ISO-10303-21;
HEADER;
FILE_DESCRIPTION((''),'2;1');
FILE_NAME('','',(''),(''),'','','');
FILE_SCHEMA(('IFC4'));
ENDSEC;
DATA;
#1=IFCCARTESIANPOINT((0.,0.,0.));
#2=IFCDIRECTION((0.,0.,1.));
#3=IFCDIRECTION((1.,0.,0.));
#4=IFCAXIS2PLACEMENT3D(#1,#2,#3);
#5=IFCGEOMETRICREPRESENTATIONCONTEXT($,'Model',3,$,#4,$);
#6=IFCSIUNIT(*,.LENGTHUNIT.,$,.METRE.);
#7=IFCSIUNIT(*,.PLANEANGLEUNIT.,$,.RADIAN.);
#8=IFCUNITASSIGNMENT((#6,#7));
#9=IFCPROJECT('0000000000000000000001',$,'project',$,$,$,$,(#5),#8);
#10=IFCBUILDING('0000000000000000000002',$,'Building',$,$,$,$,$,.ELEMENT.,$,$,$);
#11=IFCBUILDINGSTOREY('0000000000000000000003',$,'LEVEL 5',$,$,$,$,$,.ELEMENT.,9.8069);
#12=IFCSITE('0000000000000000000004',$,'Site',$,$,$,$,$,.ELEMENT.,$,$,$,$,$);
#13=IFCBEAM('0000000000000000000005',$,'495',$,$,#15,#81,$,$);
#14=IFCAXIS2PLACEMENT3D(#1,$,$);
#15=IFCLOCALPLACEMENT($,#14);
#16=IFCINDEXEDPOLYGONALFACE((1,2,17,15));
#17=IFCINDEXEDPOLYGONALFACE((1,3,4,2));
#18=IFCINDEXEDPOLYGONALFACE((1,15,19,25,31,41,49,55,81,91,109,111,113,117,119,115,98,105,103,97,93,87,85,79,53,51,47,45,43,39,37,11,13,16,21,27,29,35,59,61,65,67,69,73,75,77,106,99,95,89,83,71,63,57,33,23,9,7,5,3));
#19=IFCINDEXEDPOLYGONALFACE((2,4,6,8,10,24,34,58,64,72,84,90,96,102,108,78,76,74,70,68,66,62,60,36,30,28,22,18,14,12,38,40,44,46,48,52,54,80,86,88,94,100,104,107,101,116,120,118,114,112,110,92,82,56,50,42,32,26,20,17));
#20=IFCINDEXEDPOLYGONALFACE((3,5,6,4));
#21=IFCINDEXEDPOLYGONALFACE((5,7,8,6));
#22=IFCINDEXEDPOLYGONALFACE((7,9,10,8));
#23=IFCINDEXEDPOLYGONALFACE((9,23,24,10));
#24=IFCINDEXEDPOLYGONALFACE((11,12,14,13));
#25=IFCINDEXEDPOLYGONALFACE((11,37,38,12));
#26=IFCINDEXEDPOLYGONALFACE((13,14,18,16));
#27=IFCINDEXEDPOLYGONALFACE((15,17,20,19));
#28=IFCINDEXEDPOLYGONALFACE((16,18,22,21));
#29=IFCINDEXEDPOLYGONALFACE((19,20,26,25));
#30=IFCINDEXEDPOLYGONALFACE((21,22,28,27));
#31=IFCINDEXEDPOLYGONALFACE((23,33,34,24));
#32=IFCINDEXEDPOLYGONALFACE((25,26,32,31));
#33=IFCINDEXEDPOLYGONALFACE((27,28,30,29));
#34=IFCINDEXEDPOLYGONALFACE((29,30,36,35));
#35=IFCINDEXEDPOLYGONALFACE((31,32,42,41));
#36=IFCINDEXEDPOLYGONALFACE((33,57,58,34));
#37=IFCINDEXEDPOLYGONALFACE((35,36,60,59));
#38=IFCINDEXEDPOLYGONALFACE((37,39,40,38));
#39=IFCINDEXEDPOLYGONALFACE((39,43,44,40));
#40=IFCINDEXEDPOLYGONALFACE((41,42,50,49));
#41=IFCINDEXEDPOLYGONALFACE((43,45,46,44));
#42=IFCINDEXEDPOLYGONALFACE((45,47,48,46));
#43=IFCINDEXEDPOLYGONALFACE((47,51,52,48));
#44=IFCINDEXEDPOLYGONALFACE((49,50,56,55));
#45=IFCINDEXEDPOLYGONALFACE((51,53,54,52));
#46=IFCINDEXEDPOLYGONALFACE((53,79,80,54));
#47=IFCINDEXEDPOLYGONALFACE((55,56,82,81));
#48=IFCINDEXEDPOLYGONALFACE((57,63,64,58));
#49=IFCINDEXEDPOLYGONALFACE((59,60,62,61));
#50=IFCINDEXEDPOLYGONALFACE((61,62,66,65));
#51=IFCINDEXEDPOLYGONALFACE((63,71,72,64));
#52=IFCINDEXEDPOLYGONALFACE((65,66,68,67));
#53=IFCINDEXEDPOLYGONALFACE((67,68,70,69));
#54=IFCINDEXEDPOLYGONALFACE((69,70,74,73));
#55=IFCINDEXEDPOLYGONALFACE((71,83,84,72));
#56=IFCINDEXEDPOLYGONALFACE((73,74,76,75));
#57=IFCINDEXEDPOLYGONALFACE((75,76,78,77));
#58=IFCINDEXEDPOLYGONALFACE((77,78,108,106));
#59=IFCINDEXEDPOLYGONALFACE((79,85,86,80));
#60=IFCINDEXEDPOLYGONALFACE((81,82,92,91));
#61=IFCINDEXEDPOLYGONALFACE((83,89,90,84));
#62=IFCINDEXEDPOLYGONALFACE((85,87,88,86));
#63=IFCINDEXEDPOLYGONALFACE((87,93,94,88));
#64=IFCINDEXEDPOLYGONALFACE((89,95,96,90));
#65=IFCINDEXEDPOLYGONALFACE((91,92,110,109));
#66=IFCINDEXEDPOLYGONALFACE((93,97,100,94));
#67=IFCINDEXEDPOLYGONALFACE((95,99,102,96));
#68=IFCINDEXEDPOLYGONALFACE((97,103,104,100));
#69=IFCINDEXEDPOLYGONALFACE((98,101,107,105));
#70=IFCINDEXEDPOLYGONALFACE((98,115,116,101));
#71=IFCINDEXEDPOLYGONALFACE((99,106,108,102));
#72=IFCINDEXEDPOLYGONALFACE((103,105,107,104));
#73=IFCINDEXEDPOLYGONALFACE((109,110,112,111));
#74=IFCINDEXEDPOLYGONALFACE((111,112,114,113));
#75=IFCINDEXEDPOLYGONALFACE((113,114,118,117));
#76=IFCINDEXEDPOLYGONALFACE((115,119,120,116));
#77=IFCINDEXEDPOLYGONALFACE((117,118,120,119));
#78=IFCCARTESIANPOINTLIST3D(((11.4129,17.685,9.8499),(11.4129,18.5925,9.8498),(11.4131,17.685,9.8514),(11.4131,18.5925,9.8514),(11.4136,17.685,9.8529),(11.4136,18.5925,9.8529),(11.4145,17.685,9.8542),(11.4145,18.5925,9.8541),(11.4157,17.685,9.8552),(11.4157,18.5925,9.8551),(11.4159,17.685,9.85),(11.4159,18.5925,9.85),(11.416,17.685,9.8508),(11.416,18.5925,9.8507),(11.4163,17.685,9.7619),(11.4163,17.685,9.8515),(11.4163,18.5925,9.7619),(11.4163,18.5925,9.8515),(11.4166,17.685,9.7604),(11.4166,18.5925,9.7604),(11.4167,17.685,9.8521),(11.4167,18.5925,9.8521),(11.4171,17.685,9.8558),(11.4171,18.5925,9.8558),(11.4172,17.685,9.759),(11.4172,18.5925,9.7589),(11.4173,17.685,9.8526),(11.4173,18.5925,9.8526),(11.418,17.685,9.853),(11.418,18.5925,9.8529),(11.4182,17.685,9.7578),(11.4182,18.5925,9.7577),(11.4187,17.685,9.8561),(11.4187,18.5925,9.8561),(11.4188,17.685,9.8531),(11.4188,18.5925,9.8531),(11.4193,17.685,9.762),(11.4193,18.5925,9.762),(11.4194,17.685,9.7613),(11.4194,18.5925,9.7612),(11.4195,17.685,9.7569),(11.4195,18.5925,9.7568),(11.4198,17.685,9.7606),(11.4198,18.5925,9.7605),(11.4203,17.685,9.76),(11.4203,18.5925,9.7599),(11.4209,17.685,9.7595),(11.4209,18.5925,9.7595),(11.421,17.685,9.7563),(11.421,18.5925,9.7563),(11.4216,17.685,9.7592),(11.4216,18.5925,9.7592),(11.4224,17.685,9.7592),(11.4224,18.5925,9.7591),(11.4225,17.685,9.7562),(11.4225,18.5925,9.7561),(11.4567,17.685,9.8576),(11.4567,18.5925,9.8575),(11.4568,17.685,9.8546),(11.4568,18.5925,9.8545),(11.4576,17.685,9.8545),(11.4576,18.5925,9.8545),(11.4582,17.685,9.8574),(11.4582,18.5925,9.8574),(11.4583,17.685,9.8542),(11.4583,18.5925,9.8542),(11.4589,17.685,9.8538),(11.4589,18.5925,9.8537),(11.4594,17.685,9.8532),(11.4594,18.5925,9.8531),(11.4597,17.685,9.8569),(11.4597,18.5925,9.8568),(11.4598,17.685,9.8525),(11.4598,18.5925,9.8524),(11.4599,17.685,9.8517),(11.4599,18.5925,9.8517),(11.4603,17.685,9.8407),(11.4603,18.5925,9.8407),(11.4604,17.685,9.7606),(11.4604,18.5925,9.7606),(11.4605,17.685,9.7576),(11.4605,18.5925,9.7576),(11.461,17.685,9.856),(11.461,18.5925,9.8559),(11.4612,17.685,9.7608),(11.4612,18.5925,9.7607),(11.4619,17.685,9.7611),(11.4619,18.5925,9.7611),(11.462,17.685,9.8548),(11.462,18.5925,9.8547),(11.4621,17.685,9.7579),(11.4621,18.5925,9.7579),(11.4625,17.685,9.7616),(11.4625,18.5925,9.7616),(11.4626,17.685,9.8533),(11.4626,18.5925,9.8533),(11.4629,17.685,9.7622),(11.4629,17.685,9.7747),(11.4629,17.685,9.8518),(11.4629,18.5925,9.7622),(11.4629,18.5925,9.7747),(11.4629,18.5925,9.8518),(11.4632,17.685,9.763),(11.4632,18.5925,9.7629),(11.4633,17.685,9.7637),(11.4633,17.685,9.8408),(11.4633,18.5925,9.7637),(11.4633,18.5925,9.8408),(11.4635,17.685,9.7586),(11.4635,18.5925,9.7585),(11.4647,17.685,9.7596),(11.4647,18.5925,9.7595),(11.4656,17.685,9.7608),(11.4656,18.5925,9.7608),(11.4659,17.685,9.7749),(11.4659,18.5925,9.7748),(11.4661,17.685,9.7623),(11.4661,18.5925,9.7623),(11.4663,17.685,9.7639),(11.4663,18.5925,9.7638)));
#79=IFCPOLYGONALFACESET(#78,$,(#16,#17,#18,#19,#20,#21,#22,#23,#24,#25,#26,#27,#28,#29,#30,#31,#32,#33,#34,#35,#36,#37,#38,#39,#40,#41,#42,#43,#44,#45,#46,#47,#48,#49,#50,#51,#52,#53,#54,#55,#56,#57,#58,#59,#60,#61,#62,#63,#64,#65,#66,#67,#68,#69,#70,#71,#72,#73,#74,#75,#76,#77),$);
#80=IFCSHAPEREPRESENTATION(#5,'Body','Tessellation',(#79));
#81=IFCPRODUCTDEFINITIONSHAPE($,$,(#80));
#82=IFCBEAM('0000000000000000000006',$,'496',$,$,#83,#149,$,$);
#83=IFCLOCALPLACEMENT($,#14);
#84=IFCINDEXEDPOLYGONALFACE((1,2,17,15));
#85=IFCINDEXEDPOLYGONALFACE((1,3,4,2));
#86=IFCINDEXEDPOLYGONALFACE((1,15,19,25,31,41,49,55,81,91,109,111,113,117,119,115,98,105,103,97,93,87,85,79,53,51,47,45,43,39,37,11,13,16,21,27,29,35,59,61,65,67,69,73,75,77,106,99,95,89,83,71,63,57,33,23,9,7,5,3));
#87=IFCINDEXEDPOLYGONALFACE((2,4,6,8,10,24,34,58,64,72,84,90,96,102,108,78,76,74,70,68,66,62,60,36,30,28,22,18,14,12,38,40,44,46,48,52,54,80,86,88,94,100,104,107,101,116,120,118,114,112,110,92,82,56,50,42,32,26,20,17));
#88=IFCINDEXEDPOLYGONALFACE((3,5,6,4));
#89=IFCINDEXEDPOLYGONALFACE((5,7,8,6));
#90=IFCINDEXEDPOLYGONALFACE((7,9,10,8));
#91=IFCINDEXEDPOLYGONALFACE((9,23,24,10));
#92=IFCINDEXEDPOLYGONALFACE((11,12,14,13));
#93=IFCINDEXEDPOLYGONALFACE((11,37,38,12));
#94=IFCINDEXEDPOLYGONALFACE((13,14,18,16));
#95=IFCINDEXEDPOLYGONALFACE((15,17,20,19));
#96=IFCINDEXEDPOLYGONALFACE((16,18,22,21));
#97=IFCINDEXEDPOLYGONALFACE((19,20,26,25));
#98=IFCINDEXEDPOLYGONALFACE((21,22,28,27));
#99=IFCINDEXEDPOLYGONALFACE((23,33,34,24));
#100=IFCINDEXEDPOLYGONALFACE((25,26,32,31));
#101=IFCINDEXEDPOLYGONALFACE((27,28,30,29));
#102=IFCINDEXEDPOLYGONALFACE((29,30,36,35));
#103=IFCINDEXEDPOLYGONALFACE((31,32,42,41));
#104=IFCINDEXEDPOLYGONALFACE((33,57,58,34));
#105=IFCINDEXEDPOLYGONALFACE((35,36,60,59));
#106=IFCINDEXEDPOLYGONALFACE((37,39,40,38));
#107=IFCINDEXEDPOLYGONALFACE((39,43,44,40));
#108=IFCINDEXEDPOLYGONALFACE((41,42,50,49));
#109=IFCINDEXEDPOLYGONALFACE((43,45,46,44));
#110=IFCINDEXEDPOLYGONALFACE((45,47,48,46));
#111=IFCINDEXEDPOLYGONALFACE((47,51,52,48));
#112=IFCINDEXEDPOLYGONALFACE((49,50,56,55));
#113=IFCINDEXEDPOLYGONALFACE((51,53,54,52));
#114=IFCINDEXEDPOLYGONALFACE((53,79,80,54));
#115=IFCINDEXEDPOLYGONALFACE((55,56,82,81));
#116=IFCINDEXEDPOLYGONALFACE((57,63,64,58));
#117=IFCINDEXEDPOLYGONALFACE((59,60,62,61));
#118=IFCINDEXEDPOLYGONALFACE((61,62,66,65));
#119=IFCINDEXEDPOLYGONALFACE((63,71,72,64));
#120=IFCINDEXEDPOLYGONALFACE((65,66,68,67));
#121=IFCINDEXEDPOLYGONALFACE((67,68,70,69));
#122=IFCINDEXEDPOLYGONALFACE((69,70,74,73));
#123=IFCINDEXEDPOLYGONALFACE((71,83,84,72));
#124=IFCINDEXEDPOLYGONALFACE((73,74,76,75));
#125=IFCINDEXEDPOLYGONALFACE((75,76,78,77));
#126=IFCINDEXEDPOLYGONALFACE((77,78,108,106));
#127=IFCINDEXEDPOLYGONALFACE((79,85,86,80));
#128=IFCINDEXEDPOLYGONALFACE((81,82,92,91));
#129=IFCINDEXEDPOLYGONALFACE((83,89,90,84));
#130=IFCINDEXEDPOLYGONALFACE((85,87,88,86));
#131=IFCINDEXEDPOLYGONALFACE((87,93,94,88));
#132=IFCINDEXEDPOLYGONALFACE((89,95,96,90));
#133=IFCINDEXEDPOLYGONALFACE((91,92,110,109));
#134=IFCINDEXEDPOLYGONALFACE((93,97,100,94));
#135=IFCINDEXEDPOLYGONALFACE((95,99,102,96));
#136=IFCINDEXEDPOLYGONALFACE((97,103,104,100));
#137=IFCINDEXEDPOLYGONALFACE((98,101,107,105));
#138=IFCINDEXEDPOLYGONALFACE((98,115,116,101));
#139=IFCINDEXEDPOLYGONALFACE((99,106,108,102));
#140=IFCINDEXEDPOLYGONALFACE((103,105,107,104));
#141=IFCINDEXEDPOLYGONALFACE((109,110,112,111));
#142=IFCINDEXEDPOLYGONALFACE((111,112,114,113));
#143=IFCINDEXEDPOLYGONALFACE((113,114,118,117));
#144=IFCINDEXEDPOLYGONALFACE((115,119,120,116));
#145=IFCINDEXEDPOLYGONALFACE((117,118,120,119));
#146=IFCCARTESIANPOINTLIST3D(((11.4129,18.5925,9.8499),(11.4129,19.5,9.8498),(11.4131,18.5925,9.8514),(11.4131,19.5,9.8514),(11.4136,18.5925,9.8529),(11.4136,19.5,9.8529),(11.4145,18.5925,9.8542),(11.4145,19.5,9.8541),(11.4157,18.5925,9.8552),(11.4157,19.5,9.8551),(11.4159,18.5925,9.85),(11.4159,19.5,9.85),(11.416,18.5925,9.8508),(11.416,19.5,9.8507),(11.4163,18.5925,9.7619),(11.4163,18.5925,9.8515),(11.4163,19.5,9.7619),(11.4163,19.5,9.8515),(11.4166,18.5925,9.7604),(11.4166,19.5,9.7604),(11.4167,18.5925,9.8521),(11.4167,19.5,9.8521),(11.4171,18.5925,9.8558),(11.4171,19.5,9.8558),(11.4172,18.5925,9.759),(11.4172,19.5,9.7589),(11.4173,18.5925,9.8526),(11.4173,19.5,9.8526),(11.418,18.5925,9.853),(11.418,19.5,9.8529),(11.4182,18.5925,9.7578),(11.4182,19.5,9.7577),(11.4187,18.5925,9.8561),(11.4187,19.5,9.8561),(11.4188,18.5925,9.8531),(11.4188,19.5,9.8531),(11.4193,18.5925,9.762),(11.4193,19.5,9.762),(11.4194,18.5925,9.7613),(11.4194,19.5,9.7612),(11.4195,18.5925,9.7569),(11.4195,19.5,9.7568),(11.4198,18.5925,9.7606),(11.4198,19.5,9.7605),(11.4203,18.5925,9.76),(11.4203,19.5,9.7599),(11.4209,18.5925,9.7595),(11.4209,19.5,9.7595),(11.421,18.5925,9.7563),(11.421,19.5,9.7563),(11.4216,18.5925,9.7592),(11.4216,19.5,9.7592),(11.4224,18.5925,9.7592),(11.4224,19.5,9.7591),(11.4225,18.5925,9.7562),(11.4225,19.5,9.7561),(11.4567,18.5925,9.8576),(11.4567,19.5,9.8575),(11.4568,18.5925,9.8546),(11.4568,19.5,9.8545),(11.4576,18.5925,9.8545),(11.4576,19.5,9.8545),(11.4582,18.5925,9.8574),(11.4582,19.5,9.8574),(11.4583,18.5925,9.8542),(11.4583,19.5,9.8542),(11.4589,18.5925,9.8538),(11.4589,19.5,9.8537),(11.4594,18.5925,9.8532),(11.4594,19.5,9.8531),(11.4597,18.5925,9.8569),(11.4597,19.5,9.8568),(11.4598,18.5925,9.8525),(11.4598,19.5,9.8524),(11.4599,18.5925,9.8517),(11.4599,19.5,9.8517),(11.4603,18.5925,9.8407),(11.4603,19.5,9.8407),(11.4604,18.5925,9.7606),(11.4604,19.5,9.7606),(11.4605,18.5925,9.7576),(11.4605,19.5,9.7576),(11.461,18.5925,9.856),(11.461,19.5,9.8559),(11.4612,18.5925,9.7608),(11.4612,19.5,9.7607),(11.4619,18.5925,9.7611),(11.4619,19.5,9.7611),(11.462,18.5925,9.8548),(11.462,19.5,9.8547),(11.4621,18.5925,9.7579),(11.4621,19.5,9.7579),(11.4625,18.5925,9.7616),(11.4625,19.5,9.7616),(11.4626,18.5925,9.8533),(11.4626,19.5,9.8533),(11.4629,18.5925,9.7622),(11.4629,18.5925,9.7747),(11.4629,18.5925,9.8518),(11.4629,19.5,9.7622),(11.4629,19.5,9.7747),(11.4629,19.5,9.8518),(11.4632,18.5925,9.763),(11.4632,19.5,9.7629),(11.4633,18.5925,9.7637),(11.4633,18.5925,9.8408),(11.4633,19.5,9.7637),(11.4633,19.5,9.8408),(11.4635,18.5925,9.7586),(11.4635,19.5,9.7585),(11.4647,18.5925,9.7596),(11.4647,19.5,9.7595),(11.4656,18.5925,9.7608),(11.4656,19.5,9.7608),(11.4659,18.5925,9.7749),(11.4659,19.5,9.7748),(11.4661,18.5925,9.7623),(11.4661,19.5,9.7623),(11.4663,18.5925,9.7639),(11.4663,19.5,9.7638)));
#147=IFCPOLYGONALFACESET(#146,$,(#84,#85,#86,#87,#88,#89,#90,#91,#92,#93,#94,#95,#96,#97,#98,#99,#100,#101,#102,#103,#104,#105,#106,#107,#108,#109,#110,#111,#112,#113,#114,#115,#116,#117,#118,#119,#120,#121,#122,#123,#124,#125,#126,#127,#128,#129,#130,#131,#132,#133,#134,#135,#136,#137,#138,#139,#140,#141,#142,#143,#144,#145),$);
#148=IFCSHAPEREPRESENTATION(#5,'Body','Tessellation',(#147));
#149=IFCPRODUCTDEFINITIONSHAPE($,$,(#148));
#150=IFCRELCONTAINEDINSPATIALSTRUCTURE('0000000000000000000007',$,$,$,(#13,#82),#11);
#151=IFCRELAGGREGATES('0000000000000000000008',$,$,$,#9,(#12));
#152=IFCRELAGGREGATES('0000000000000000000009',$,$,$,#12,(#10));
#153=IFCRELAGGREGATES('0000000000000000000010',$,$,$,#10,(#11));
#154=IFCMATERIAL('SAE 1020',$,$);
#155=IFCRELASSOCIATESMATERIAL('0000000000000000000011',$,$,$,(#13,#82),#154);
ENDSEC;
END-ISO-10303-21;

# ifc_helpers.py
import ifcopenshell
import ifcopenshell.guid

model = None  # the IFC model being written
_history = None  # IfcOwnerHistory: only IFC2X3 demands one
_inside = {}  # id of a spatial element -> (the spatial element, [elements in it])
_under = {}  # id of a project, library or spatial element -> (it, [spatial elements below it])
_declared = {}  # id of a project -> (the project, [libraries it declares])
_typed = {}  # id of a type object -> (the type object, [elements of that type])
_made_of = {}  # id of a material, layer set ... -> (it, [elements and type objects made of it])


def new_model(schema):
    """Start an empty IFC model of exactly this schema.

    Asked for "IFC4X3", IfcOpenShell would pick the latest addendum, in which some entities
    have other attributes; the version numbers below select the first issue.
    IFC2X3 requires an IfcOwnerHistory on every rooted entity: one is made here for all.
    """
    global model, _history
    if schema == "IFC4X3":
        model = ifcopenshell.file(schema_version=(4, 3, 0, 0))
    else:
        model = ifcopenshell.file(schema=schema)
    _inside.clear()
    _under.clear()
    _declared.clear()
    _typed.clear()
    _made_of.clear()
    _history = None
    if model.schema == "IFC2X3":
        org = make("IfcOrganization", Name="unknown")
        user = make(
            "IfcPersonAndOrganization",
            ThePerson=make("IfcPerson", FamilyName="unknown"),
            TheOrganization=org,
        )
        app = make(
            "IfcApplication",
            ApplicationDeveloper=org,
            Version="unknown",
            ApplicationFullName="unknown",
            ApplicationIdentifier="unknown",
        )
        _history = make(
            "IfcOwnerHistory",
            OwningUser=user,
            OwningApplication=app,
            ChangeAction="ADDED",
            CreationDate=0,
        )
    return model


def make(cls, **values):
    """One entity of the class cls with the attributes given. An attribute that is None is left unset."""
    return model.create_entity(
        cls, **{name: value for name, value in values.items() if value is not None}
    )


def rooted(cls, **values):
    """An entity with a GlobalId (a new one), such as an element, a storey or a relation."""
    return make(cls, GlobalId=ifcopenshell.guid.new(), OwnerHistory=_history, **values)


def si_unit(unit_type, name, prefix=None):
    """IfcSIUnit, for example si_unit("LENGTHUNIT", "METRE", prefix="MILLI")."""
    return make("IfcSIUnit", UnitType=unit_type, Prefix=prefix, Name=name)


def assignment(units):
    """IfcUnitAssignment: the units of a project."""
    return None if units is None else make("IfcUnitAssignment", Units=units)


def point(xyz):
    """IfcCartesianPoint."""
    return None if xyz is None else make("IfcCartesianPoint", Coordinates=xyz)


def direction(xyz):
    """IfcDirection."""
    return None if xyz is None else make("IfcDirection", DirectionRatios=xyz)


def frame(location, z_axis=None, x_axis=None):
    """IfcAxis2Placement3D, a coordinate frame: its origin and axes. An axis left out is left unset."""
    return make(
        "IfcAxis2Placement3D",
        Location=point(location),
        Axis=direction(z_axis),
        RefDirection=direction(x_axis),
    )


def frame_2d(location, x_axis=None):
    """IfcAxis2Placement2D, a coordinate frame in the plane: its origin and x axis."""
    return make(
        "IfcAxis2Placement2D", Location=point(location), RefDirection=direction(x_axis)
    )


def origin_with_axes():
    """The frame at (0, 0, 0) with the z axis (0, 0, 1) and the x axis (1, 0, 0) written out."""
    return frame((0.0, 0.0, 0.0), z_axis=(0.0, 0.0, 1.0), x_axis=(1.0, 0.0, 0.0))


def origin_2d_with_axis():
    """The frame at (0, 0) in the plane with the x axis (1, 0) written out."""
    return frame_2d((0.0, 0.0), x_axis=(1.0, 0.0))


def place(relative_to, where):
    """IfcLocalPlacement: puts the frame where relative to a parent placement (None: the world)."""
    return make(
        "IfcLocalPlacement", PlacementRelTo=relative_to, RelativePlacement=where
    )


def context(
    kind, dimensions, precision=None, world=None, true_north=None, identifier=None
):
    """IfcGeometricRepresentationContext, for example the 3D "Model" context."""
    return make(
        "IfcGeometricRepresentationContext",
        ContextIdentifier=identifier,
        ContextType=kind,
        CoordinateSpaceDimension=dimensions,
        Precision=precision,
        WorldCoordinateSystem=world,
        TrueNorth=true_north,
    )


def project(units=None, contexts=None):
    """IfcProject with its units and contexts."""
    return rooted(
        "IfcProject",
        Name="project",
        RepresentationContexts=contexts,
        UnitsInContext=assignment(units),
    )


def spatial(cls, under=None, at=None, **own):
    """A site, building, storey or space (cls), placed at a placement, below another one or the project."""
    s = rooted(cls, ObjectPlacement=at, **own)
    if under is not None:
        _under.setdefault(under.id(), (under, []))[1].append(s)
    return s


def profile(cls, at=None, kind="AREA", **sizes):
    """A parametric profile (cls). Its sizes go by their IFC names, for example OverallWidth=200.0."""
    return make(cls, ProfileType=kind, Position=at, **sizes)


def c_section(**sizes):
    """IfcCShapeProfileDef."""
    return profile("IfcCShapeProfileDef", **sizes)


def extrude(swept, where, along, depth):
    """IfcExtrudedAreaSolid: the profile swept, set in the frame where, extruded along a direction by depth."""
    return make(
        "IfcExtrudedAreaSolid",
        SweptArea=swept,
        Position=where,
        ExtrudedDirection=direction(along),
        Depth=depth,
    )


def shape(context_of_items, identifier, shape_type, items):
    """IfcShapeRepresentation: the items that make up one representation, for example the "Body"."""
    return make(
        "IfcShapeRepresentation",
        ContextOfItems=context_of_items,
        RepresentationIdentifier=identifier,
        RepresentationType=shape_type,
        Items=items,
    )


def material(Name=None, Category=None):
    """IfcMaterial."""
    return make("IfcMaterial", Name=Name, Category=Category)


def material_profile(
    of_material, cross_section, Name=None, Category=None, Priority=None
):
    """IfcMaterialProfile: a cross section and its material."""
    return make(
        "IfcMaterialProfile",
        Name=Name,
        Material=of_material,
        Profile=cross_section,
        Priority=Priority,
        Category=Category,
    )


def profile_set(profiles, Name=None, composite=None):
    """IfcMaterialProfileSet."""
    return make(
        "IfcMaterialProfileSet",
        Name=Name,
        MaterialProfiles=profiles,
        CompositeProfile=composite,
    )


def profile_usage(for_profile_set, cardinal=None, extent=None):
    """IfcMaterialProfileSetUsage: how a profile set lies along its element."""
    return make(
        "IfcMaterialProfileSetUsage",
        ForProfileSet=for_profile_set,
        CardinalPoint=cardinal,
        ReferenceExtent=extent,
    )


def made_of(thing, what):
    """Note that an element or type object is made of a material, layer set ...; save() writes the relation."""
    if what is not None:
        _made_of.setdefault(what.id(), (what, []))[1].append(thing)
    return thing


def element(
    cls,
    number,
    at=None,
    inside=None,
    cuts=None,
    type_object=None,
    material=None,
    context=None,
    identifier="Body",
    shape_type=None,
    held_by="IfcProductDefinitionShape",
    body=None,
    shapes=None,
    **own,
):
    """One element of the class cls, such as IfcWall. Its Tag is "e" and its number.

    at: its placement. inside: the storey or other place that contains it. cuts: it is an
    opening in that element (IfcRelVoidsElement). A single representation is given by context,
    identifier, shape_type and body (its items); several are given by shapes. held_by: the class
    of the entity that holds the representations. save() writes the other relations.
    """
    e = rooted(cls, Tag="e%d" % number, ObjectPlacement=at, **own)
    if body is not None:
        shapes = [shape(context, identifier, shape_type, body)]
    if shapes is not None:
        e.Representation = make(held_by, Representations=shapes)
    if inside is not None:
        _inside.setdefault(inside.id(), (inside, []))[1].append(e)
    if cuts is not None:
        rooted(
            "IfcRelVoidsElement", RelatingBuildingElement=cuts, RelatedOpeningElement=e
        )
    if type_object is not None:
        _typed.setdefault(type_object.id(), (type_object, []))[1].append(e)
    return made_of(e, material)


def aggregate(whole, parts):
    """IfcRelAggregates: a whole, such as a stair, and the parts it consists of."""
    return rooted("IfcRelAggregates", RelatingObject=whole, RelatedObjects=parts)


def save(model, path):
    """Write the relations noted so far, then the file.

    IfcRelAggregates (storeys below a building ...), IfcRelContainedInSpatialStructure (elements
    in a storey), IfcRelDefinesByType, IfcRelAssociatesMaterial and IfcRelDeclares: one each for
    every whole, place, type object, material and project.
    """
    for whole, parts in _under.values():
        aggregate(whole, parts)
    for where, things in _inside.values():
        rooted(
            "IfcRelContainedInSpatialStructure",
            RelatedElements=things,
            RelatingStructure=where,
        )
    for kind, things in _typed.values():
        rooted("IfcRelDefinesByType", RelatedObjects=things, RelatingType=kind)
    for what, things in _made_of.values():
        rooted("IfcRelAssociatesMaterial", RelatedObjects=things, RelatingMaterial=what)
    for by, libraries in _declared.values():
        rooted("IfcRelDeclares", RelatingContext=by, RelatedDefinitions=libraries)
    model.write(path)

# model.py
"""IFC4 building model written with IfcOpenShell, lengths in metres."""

from ifc_helpers import new_model, si_unit, frame, origin_with_axes, origin_2d_with_axis, place, context, project, spatial, c_section, extrude, material, material_profile, profile_set, profile_usage, element, save


model = new_model("IFC4")

# Units and contexts
model_context = context("Model", 3, world=origin_with_axes())
ifc_project = project(units=[si_unit("LENGTHUNIT", "METRE"), si_unit("PLANEANGLEUNIT", "RADIAN")], contexts=[model_context])

# Site, building, storey
site = spatial("IfcSite", under=ifc_project, Name="Site", CompositionType="ELEMENT")
building = spatial("IfcBuilding", under=site, Name="Building", CompositionType="ELEMENT")
storey = spatial("IfcBuildingStorey", under=building, Name="LEVEL 5", CompositionType="ELEMENT", Elevation=9.8069)

# Beams
ifc_material = material(Name="SAE 1020")
ifc_material_profile_1 = material_profile(ifc_material, c_section(Depth=0.1, Width=0.05, WallThickness=0.003, Girth=0.017, InternalFilletRadius=0.003, at=origin_2d_with_axis()))
ifc_profile_set_1 = profile_set([ifc_material_profile_1])
ifc_profile_usage_1 = profile_usage(ifc_profile_set_1, cardinal=10)
beam_1_placement = place(None, frame((11.4396, 17.685, 9.8069), z_axis=(0.0, 1.0, -0.00003), x_axis=(0.999256, 0.000001, 0.038562)))
element("IfcBeam", 1, at=beam_1_placement, inside=storey, material=ifc_profile_usage_1, Name="495", context=model_context, shape_type="SweptSolid", body=[
    extrude(c_section(Depth=0.1, Width=0.05, WallThickness=0.003, Girth=0.017, InternalFilletRadius=0.003, at=origin_2d_with_axis()), origin_with_axes(), (0.0, 0.0, 1.0), 0.9075),
])
ifc_material_profile_2 = material_profile(ifc_material, c_section(Depth=0.1, Width=0.05, WallThickness=0.003, Girth=0.017, InternalFilletRadius=0.003, at=origin_2d_with_axis()))
ifc_profile_set_2 = profile_set([ifc_material_profile_2])
ifc_profile_usage_2 = profile_usage(ifc_profile_set_2, cardinal=10)
beam_2_placement = place(None, frame((11.4396, 18.5925, 9.8069), z_axis=(0.0, 1.0, -0.00003), x_axis=(0.999256, 0.000001, 0.038562)))
element("IfcBeam", 2, at=beam_2_placement, inside=storey, material=ifc_profile_usage_2, Name="496", context=model_context, shape_type="SweptSolid", body=[
    extrude(c_section(Depth=0.1, Width=0.05, WallThickness=0.003, Girth=0.017, InternalFilletRadius=0.003, at=origin_2d_with_axis()), origin_with_axes(), (0.0, 0.0, 1.0), 0.9075),
])

save(model, "model.ifc")
